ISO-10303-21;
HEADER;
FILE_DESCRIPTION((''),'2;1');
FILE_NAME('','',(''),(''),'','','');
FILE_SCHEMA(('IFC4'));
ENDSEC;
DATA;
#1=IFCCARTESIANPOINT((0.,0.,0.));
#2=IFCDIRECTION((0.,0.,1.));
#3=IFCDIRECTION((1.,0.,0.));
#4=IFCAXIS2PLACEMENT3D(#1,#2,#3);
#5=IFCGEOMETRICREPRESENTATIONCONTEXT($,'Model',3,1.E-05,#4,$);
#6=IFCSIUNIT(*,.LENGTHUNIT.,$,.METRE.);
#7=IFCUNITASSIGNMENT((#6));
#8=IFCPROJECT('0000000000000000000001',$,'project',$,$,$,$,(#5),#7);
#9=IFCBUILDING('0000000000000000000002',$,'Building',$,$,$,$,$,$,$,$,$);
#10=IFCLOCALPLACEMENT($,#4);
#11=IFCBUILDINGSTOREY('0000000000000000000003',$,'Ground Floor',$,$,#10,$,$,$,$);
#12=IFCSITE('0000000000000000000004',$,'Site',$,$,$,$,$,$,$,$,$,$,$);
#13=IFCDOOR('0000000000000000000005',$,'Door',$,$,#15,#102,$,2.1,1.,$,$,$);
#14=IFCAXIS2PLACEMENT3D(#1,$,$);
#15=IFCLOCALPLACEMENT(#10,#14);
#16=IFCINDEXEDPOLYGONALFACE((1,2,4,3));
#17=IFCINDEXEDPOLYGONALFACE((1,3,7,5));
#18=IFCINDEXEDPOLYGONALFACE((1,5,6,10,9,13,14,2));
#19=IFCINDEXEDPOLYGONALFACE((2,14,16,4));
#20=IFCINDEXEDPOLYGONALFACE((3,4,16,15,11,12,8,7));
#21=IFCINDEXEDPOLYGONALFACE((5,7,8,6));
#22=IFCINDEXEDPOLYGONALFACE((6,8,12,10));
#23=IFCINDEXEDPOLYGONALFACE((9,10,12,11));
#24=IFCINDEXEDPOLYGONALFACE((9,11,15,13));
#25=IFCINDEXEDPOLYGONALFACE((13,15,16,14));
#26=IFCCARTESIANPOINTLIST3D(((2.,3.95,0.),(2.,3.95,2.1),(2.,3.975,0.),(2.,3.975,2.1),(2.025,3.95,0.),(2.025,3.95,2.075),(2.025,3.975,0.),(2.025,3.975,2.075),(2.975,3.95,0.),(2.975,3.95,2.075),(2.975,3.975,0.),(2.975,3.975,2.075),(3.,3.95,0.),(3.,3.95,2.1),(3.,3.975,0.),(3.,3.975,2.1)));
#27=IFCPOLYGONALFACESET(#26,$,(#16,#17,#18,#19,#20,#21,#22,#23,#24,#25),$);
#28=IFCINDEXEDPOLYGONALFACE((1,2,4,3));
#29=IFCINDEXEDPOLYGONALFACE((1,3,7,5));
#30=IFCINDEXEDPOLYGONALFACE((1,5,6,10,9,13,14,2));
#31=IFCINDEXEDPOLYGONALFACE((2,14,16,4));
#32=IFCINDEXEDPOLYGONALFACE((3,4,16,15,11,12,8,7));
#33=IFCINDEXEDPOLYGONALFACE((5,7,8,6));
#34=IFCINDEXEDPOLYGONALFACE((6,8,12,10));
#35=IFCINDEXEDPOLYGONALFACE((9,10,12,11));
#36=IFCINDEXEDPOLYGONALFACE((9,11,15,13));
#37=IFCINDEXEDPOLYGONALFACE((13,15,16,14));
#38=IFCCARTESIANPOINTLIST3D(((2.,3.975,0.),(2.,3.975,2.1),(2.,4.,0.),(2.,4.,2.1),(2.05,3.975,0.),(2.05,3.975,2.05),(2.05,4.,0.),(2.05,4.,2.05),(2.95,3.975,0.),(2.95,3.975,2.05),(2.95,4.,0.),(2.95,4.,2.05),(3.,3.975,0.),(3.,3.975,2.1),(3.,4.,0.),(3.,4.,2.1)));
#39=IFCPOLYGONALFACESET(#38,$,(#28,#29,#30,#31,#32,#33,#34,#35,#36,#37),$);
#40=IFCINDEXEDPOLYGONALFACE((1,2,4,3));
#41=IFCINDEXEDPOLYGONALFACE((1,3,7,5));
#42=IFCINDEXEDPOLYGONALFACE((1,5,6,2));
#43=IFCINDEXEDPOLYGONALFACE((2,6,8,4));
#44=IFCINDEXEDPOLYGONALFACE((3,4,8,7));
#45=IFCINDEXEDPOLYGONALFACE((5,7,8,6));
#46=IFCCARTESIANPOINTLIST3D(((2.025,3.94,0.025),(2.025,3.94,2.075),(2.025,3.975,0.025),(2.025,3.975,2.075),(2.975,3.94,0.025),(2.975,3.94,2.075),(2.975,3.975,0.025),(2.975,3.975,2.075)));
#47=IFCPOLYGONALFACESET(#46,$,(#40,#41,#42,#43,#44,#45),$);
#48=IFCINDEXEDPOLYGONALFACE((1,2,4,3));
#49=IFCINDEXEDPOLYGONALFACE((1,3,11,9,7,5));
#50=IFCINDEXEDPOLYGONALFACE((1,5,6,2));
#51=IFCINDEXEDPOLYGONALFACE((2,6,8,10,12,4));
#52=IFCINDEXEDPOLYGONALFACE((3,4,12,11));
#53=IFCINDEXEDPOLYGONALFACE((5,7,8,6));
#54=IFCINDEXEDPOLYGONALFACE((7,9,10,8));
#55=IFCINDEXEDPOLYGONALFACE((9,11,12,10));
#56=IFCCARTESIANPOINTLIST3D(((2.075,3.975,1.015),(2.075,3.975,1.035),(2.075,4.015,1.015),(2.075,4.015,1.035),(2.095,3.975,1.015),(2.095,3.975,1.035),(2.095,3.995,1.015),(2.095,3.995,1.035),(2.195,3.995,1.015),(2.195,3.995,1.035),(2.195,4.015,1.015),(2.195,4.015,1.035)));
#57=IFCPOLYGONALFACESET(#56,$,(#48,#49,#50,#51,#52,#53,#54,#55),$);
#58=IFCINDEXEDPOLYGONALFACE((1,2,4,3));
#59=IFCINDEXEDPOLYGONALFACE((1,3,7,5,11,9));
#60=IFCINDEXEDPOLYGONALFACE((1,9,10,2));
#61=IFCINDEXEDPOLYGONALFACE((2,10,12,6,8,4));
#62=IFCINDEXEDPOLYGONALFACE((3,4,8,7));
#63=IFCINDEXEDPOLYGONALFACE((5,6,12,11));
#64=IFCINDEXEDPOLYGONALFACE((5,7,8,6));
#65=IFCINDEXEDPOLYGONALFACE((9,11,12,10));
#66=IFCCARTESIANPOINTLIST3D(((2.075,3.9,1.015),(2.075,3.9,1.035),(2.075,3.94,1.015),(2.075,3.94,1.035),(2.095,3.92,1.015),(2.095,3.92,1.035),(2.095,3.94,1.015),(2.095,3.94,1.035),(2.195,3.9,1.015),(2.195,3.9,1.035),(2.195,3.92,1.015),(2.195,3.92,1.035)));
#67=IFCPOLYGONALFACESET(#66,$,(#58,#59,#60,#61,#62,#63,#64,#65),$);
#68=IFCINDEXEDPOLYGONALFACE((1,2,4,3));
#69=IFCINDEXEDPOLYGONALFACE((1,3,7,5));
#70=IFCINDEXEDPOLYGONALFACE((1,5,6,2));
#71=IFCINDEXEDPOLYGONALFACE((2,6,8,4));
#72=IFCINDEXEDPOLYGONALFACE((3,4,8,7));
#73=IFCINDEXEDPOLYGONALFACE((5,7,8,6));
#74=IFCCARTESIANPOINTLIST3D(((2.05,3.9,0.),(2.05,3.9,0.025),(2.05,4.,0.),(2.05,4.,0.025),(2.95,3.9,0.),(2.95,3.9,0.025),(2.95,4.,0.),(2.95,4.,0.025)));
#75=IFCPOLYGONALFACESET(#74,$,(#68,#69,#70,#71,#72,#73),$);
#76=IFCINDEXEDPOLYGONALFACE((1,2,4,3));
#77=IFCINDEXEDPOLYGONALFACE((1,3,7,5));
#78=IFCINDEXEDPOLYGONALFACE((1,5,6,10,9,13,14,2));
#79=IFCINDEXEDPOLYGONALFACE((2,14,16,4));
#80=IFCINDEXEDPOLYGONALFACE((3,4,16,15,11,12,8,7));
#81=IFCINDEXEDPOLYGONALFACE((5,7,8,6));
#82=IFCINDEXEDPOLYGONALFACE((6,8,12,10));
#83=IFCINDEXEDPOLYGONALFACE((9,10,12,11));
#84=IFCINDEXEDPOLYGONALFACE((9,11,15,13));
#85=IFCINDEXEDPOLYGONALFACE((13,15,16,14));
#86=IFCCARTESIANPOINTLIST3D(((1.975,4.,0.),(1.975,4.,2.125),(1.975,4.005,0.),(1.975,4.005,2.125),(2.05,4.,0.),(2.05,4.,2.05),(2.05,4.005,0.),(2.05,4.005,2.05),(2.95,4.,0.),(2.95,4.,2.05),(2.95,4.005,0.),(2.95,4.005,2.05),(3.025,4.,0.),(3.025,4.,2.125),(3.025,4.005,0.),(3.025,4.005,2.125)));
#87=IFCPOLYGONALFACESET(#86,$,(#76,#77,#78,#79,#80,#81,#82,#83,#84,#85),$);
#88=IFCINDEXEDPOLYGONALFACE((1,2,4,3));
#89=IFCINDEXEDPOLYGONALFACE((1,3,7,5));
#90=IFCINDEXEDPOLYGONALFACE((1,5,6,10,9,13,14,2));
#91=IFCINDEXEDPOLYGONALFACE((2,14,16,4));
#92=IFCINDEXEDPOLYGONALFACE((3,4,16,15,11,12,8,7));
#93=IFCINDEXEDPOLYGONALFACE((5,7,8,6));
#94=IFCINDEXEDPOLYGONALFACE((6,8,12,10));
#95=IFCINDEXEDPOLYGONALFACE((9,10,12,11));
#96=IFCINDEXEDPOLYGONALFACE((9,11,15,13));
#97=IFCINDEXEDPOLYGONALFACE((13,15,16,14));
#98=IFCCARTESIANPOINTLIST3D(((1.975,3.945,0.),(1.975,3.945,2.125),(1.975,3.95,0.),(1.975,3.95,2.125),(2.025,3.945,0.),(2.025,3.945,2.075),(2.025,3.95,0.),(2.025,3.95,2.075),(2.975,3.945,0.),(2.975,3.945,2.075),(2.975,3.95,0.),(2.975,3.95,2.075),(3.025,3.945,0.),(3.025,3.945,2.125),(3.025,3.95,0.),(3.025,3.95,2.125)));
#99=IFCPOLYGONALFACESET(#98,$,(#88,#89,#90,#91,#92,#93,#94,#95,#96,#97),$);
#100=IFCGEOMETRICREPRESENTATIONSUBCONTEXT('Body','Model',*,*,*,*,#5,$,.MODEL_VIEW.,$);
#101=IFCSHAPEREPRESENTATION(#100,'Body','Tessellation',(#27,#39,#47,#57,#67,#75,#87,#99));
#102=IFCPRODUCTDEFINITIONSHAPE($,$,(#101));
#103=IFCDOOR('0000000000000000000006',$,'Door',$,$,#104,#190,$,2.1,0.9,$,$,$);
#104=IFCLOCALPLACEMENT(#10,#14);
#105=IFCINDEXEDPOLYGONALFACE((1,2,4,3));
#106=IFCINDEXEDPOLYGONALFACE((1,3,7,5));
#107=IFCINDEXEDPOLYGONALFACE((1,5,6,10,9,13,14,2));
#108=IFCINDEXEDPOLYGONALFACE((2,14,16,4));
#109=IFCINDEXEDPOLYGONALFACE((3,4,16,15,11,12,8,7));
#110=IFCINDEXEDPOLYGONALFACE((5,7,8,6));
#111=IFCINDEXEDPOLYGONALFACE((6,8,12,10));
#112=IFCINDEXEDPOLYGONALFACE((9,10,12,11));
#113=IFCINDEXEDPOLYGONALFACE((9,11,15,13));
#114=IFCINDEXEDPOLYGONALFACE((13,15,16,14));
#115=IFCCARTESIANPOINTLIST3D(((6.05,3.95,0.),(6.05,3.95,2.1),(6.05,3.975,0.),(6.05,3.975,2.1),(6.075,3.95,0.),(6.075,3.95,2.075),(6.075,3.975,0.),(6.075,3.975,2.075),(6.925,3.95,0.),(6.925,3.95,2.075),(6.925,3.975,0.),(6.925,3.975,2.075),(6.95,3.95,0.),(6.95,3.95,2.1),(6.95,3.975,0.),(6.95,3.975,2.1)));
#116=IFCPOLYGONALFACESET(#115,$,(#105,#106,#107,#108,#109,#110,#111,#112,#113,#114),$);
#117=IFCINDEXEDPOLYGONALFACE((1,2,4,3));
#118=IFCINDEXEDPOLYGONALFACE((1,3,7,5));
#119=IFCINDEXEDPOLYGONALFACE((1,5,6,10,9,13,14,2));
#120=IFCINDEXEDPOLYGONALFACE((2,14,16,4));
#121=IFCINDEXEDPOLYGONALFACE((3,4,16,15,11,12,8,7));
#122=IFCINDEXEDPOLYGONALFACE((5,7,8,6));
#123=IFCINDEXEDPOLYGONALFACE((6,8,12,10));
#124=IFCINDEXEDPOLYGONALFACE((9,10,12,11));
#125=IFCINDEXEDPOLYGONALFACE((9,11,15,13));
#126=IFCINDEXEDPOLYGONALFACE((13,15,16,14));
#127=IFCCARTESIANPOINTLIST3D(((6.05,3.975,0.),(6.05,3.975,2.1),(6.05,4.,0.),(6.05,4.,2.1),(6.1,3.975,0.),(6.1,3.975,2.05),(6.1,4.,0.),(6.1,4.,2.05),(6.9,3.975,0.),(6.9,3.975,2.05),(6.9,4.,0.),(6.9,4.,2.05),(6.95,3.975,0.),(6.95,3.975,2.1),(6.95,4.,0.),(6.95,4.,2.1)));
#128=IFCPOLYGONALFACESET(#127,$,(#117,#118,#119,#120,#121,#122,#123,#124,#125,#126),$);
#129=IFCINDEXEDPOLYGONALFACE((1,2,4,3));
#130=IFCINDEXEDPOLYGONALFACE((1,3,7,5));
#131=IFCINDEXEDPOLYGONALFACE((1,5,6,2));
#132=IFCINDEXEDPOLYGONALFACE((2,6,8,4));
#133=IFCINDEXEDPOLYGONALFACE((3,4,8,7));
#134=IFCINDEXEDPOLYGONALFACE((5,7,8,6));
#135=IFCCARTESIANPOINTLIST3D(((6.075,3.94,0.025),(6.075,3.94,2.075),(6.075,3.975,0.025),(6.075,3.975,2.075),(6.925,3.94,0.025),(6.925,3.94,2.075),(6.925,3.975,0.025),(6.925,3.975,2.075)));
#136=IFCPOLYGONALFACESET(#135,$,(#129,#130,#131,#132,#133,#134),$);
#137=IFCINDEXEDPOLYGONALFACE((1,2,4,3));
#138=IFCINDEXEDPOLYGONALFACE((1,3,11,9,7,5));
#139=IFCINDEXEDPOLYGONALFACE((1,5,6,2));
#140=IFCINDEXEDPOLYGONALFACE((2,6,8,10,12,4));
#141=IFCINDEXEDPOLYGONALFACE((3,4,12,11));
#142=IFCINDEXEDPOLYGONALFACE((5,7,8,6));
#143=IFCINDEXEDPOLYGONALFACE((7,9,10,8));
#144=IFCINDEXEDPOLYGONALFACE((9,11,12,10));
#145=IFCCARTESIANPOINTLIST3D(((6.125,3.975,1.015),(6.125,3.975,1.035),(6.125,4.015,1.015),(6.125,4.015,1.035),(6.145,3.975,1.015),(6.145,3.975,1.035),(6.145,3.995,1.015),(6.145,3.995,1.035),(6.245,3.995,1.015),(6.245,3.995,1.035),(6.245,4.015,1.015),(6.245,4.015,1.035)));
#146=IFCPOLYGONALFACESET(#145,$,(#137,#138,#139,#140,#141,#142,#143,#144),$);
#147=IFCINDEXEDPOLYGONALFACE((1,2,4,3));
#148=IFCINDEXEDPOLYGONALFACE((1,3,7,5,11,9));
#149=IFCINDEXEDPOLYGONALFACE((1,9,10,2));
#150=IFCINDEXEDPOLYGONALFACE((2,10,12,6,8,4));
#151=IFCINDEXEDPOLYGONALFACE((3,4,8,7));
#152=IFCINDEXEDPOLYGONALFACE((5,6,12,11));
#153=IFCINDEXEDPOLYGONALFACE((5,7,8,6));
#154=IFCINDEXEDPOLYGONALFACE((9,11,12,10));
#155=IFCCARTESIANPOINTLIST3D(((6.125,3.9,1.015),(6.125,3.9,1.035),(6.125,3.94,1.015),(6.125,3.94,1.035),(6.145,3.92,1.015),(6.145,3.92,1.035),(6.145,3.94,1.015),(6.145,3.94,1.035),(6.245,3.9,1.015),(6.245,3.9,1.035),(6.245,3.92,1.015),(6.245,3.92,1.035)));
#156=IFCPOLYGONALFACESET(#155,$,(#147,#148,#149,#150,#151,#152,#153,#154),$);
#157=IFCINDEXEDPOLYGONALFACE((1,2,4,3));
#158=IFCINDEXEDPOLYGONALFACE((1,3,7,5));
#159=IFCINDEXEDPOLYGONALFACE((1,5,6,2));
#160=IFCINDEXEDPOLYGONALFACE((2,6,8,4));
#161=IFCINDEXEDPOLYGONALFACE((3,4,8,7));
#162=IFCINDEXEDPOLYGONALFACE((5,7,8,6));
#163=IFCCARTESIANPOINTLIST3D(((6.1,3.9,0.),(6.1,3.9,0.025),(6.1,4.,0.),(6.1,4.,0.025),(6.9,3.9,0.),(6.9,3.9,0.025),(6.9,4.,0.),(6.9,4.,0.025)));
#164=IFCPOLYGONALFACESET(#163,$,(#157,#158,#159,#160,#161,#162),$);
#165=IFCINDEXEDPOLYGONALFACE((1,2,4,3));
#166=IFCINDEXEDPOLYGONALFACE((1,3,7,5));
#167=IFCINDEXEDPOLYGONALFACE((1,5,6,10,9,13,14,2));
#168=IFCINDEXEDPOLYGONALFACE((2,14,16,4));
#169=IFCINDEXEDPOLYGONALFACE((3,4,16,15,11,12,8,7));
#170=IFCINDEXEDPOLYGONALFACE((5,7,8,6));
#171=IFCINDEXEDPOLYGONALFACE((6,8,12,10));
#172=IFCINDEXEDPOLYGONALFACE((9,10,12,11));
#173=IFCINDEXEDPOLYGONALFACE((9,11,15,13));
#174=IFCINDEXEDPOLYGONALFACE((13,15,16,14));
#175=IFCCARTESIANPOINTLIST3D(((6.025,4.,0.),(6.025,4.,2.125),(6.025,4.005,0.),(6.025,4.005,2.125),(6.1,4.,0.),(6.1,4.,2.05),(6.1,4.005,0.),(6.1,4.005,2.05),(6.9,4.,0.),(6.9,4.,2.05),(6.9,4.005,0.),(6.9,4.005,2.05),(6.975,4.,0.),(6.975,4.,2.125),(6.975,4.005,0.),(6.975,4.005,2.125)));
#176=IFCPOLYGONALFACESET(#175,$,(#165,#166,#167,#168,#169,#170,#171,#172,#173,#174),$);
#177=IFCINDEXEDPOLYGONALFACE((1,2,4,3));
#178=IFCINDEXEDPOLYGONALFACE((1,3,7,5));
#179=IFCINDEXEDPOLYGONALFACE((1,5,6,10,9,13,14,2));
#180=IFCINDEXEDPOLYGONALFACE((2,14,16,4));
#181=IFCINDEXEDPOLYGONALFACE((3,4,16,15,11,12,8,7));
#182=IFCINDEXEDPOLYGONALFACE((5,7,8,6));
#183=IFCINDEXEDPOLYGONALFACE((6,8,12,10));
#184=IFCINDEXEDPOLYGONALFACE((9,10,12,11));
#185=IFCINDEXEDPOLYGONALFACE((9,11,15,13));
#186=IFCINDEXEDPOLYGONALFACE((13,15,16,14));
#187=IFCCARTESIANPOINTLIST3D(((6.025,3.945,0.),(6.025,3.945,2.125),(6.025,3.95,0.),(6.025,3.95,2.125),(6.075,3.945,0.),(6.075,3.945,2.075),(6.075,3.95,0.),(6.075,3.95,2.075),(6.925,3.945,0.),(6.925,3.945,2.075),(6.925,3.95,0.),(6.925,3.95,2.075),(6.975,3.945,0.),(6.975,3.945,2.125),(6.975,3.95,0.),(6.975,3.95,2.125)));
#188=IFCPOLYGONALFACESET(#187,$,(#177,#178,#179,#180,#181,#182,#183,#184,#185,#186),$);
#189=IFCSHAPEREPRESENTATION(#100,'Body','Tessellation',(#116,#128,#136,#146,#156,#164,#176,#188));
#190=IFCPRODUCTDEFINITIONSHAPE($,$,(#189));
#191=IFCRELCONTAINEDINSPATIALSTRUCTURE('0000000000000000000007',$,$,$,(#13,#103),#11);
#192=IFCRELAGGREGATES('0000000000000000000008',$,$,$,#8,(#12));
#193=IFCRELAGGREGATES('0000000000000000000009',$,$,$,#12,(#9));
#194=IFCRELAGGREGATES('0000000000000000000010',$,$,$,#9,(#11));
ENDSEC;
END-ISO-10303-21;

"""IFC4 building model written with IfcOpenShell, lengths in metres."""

from ifc_helpers import new_model, si_unit, frame, origin_with_axes, place, context, subcontext, project, spatial, line, indexed_curve, outline, extrude, element, save


model = new_model("IFC4")

# Units and contexts
model_context = context("Model", 3, precision=1e-05, world=origin_with_axes())
body_context = subcontext(model_context, "Body", "Model", "MODEL_VIEW")
ifc_project = project(units=[si_unit("LENGTHUNIT", "METRE")], contexts=[model_context])

# Site, building, storey
site = spatial("IfcSite", under=ifc_project, Name="Site")
building = spatial("IfcBuilding", under=site, Name="Building")
storey_placement = place(None, origin_with_axes())
storey = spatial("IfcBuildingStorey", under=building, at=storey_placement, Name="Ground Floor")

# Doors
door_1_placement = place(storey_placement, frame((3.0, 4.0, 0.0), z_axis=(0.0, 0.0, 1.0), x_axis=(-1.0, 0.0, 0.0)))
element("IfcDoor", 1, at=door_1_placement, inside=storey, Name="Door", OverallHeight=2.1, OverallWidth=1.0, context=body_context, shape_type="SweptSolid", body=[
    extrude(outline(indexed_curve([(0.0, 0.0), (0.0, 2.1), (1.0, 2.1), (1.0, 0.0), (0.975, 0.0), (0.975, 2.075), (0.025, 2.075), (0.025, 0.0)], segments=[line(1, 2, 3, 4, 5, 6, 7, 8, 1)])), frame((0.0, 0.025, 0.0), z_axis=(0.0, -1.0, 0.0), x_axis=(1.0, 0.0, 0.0)), (0.0, 0.0, -1.0), 0.025),
    extrude(outline(indexed_curve([(0.0, 0.0), (0.0, 2.1), (1.0, 2.1), (1.0, 0.0), (0.95, 0.0), (0.95, 2.05), (0.05, 2.05), (0.05, 0.0)], segments=[line(1, 2, 3, 4, 5, 6, 7, 8, 1)])), frame((0.0, 0.0, 0.0), z_axis=(0.0, -1.0, 0.0), x_axis=(1.0, 0.0, 0.0)), (0.0, 0.0, -1.0), 0.025),
    extrude(outline(indexed_curve([(0.0, 0.0), (0.95, 0.0), (0.95, 0.035), (0.0, 0.035)], segments=[line(1, 2, 3, 4, 1)])), frame((0.025, 0.025, 0.025), z_axis=(0.0, 0.0, 1.0), x_axis=(1.0, 0.0, 0.0)), (0.0, 0.0, 1.0), 2.05),
    extrude(outline(indexed_curve([(0.0, 0.0), (0.0, -0.04), (-0.12, -0.04), (-0.12, -0.02), (-0.02, -0.02), (-0.02, 0.0)], segments=[line(1, 2, 3, 4, 5, 6, 1)])), frame((0.925, 0.025, 1.015), z_axis=(0.0, 0.0, 1.0), x_axis=(1.0, 0.0, 0.0)), (0.0, 0.0, 1.0), 0.02),
    extrude(outline(indexed_curve([(0.0, 0.0), (0.0, 0.04), (-0.12, 0.04), (-0.12, 0.02), (-0.02, 0.02), (-0.02, 0.0)], segments=[line(1, 2, 3, 4, 5, 6, 1)])), frame((0.925, 0.06, 1.015), z_axis=(0.0, 0.0, 1.0), x_axis=(1.0, 0.0, 0.0)), (0.0, 0.0, 1.0), 0.02),
    extrude(outline(indexed_curve([(0.0, 0.0), (0.9, 0.0), (0.9, 0.1), (0.0, 0.1)], segments=[line(1, 2, 3, 4, 1)])), frame((0.05, 0.0, 0.0), z_axis=(0.0, 0.0, 1.0), x_axis=(1.0, 0.0, 0.0)), (0.0, 0.0, 1.0), 0.025),
    extrude(outline(indexed_curve([(0.0, 0.0), (0.0, 2.125), (1.05, 2.125), (1.05, 0.0), (0.975, 0.0), (0.975, 2.05), (0.075, 2.05), (0.075, 0.0)], segments=[line(1, 2, 3, 4, 5, 6, 7, 8, 1)])), frame((-0.025, -0.005, 0.0), z_axis=(0.0, -1.0, 0.0), x_axis=(1.0, 0.0, 0.0)), (0.0, 0.0, -1.0), 0.005),
    extrude(outline(indexed_curve([(0.0, 0.0), (0.0, 2.125), (1.05, 2.125), (1.05, 0.0), (1.0, 0.0), (1.0, 2.075), (0.05, 2.075), (0.05, 0.0)], segments=[line(1, 2, 3, 4, 5, 6, 7, 8, 1)])), frame((-0.025, 0.05, 0.0), z_axis=(0.0, -1.0, 0.0), x_axis=(1.0, 0.0, 0.0)), (0.0, 0.0, -1.0), 0.005),
])
door_2_placement = place(storey_placement, frame((6.95, 4.0, 0.0), z_axis=(0.0, 0.0, 1.0), x_axis=(-1.0, 0.0, 0.0)))
element("IfcDoor", 2, at=door_2_placement, inside=storey, Name="Door", OverallHeight=2.1, OverallWidth=0.9, context=body_context, shape_type="SweptSolid", body=[
    extrude(outline(indexed_curve([(0.0, 0.0), (0.0, 2.1), (0.9, 2.1), (0.9, 0.0), (0.875, 0.0), (0.875, 2.075), (0.025, 2.075), (0.025, 0.0)], segments=[line(1, 2, 3, 4, 5, 6, 7, 8, 1)])), frame((0.0, 0.025, 0.0), z_axis=(0.0, -1.0, 0.0), x_axis=(1.0, 0.0, 0.0)), (0.0, 0.0, -1.0), 0.025),
    extrude(outline(indexed_curve([(0.0, 0.0), (0.0, 2.1), (0.9, 2.1), (0.9, 0.0), (0.85, 0.0), (0.85, 2.05), (0.05, 2.05), (0.05, 0.0)], segments=[line(1, 2, 3, 4, 5, 6, 7, 8, 1)])), frame((0.0, 0.0, 0.0), z_axis=(0.0, -1.0, 0.0), x_axis=(1.0, 0.0, 0.0)), (0.0, 0.0, -1.0), 0.025),
    extrude(outline(indexed_curve([(0.0, 0.0), (0.85, 0.0), (0.85, 0.035), (0.0, 0.035)], segments=[line(1, 2, 3, 4, 1)])), frame((0.025, 0.025, 0.025), z_axis=(0.0, 0.0, 1.0), x_axis=(1.0, 0.0, 0.0)), (0.0, 0.0, 1.0), 2.05),
    extrude(outline(indexed_curve([(0.0, 0.0), (0.0, -0.04), (-0.12, -0.04), (-0.12, -0.02), (-0.02, -0.02), (-0.02, 0.0)], segments=[line(1, 2, 3, 4, 5, 6, 1)])), frame((0.825, 0.025, 1.015), z_axis=(0.0, 0.0, 1.0), x_axis=(1.0, 0.0, 0.0)), (0.0, 0.0, 1.0), 0.02),
    extrude(outline(indexed_curve([(0.0, 0.0), (0.0, 0.04), (-0.12, 0.04), (-0.12, 0.02), (-0.02, 0.02), (-0.02, 0.0)], segments=[line(1, 2, 3, 4, 5, 6, 1)])), frame((0.825, 0.06, 1.015), z_axis=(0.0, 0.0, 1.0), x_axis=(1.0, 0.0, 0.0)), (0.0, 0.0, 1.0), 0.02),
    extrude(outline(indexed_curve([(0.0, 0.0), (0.8, 0.0), (0.8, 0.1), (0.0, 0.1)], segments=[line(1, 2, 3, 4, 1)])), frame((0.05, 0.0, 0.0), z_axis=(0.0, 0.0, 1.0), x_axis=(1.0, 0.0, 0.0)), (0.0, 0.0, 1.0), 0.025),
    extrude(outline(indexed_curve([(0.0, 0.0), (0.0, 2.125), (0.95, 2.125), (0.95, 0.0), (0.875, 0.0), (0.875, 2.05), (0.075, 2.05), (0.075, 0.0)], segments=[line(1, 2, 3, 4, 5, 6, 7, 8, 1)])), frame((-0.025, -0.005, 0.0), z_axis=(0.0, -1.0, 0.0), x_axis=(1.0, 0.0, 0.0)), (0.0, 0.0, -1.0), 0.005),
    extrude(outline(indexed_curve([(0.0, 0.0), (0.0, 2.125), (0.95, 2.125), (0.95, 0.0), (0.9, 0.0), (0.9, 2.075), (0.05, 2.075), (0.05, 0.0)], segments=[line(1, 2, 3, 4, 5, 6, 7, 8, 1)])), frame((-0.025, 0.05, 0.0), z_axis=(0.0, -1.0, 0.0), x_axis=(1.0, 0.0, 0.0)), (0.0, 0.0, -1.0), 0.005),
])

save(model, "model.ifc")
